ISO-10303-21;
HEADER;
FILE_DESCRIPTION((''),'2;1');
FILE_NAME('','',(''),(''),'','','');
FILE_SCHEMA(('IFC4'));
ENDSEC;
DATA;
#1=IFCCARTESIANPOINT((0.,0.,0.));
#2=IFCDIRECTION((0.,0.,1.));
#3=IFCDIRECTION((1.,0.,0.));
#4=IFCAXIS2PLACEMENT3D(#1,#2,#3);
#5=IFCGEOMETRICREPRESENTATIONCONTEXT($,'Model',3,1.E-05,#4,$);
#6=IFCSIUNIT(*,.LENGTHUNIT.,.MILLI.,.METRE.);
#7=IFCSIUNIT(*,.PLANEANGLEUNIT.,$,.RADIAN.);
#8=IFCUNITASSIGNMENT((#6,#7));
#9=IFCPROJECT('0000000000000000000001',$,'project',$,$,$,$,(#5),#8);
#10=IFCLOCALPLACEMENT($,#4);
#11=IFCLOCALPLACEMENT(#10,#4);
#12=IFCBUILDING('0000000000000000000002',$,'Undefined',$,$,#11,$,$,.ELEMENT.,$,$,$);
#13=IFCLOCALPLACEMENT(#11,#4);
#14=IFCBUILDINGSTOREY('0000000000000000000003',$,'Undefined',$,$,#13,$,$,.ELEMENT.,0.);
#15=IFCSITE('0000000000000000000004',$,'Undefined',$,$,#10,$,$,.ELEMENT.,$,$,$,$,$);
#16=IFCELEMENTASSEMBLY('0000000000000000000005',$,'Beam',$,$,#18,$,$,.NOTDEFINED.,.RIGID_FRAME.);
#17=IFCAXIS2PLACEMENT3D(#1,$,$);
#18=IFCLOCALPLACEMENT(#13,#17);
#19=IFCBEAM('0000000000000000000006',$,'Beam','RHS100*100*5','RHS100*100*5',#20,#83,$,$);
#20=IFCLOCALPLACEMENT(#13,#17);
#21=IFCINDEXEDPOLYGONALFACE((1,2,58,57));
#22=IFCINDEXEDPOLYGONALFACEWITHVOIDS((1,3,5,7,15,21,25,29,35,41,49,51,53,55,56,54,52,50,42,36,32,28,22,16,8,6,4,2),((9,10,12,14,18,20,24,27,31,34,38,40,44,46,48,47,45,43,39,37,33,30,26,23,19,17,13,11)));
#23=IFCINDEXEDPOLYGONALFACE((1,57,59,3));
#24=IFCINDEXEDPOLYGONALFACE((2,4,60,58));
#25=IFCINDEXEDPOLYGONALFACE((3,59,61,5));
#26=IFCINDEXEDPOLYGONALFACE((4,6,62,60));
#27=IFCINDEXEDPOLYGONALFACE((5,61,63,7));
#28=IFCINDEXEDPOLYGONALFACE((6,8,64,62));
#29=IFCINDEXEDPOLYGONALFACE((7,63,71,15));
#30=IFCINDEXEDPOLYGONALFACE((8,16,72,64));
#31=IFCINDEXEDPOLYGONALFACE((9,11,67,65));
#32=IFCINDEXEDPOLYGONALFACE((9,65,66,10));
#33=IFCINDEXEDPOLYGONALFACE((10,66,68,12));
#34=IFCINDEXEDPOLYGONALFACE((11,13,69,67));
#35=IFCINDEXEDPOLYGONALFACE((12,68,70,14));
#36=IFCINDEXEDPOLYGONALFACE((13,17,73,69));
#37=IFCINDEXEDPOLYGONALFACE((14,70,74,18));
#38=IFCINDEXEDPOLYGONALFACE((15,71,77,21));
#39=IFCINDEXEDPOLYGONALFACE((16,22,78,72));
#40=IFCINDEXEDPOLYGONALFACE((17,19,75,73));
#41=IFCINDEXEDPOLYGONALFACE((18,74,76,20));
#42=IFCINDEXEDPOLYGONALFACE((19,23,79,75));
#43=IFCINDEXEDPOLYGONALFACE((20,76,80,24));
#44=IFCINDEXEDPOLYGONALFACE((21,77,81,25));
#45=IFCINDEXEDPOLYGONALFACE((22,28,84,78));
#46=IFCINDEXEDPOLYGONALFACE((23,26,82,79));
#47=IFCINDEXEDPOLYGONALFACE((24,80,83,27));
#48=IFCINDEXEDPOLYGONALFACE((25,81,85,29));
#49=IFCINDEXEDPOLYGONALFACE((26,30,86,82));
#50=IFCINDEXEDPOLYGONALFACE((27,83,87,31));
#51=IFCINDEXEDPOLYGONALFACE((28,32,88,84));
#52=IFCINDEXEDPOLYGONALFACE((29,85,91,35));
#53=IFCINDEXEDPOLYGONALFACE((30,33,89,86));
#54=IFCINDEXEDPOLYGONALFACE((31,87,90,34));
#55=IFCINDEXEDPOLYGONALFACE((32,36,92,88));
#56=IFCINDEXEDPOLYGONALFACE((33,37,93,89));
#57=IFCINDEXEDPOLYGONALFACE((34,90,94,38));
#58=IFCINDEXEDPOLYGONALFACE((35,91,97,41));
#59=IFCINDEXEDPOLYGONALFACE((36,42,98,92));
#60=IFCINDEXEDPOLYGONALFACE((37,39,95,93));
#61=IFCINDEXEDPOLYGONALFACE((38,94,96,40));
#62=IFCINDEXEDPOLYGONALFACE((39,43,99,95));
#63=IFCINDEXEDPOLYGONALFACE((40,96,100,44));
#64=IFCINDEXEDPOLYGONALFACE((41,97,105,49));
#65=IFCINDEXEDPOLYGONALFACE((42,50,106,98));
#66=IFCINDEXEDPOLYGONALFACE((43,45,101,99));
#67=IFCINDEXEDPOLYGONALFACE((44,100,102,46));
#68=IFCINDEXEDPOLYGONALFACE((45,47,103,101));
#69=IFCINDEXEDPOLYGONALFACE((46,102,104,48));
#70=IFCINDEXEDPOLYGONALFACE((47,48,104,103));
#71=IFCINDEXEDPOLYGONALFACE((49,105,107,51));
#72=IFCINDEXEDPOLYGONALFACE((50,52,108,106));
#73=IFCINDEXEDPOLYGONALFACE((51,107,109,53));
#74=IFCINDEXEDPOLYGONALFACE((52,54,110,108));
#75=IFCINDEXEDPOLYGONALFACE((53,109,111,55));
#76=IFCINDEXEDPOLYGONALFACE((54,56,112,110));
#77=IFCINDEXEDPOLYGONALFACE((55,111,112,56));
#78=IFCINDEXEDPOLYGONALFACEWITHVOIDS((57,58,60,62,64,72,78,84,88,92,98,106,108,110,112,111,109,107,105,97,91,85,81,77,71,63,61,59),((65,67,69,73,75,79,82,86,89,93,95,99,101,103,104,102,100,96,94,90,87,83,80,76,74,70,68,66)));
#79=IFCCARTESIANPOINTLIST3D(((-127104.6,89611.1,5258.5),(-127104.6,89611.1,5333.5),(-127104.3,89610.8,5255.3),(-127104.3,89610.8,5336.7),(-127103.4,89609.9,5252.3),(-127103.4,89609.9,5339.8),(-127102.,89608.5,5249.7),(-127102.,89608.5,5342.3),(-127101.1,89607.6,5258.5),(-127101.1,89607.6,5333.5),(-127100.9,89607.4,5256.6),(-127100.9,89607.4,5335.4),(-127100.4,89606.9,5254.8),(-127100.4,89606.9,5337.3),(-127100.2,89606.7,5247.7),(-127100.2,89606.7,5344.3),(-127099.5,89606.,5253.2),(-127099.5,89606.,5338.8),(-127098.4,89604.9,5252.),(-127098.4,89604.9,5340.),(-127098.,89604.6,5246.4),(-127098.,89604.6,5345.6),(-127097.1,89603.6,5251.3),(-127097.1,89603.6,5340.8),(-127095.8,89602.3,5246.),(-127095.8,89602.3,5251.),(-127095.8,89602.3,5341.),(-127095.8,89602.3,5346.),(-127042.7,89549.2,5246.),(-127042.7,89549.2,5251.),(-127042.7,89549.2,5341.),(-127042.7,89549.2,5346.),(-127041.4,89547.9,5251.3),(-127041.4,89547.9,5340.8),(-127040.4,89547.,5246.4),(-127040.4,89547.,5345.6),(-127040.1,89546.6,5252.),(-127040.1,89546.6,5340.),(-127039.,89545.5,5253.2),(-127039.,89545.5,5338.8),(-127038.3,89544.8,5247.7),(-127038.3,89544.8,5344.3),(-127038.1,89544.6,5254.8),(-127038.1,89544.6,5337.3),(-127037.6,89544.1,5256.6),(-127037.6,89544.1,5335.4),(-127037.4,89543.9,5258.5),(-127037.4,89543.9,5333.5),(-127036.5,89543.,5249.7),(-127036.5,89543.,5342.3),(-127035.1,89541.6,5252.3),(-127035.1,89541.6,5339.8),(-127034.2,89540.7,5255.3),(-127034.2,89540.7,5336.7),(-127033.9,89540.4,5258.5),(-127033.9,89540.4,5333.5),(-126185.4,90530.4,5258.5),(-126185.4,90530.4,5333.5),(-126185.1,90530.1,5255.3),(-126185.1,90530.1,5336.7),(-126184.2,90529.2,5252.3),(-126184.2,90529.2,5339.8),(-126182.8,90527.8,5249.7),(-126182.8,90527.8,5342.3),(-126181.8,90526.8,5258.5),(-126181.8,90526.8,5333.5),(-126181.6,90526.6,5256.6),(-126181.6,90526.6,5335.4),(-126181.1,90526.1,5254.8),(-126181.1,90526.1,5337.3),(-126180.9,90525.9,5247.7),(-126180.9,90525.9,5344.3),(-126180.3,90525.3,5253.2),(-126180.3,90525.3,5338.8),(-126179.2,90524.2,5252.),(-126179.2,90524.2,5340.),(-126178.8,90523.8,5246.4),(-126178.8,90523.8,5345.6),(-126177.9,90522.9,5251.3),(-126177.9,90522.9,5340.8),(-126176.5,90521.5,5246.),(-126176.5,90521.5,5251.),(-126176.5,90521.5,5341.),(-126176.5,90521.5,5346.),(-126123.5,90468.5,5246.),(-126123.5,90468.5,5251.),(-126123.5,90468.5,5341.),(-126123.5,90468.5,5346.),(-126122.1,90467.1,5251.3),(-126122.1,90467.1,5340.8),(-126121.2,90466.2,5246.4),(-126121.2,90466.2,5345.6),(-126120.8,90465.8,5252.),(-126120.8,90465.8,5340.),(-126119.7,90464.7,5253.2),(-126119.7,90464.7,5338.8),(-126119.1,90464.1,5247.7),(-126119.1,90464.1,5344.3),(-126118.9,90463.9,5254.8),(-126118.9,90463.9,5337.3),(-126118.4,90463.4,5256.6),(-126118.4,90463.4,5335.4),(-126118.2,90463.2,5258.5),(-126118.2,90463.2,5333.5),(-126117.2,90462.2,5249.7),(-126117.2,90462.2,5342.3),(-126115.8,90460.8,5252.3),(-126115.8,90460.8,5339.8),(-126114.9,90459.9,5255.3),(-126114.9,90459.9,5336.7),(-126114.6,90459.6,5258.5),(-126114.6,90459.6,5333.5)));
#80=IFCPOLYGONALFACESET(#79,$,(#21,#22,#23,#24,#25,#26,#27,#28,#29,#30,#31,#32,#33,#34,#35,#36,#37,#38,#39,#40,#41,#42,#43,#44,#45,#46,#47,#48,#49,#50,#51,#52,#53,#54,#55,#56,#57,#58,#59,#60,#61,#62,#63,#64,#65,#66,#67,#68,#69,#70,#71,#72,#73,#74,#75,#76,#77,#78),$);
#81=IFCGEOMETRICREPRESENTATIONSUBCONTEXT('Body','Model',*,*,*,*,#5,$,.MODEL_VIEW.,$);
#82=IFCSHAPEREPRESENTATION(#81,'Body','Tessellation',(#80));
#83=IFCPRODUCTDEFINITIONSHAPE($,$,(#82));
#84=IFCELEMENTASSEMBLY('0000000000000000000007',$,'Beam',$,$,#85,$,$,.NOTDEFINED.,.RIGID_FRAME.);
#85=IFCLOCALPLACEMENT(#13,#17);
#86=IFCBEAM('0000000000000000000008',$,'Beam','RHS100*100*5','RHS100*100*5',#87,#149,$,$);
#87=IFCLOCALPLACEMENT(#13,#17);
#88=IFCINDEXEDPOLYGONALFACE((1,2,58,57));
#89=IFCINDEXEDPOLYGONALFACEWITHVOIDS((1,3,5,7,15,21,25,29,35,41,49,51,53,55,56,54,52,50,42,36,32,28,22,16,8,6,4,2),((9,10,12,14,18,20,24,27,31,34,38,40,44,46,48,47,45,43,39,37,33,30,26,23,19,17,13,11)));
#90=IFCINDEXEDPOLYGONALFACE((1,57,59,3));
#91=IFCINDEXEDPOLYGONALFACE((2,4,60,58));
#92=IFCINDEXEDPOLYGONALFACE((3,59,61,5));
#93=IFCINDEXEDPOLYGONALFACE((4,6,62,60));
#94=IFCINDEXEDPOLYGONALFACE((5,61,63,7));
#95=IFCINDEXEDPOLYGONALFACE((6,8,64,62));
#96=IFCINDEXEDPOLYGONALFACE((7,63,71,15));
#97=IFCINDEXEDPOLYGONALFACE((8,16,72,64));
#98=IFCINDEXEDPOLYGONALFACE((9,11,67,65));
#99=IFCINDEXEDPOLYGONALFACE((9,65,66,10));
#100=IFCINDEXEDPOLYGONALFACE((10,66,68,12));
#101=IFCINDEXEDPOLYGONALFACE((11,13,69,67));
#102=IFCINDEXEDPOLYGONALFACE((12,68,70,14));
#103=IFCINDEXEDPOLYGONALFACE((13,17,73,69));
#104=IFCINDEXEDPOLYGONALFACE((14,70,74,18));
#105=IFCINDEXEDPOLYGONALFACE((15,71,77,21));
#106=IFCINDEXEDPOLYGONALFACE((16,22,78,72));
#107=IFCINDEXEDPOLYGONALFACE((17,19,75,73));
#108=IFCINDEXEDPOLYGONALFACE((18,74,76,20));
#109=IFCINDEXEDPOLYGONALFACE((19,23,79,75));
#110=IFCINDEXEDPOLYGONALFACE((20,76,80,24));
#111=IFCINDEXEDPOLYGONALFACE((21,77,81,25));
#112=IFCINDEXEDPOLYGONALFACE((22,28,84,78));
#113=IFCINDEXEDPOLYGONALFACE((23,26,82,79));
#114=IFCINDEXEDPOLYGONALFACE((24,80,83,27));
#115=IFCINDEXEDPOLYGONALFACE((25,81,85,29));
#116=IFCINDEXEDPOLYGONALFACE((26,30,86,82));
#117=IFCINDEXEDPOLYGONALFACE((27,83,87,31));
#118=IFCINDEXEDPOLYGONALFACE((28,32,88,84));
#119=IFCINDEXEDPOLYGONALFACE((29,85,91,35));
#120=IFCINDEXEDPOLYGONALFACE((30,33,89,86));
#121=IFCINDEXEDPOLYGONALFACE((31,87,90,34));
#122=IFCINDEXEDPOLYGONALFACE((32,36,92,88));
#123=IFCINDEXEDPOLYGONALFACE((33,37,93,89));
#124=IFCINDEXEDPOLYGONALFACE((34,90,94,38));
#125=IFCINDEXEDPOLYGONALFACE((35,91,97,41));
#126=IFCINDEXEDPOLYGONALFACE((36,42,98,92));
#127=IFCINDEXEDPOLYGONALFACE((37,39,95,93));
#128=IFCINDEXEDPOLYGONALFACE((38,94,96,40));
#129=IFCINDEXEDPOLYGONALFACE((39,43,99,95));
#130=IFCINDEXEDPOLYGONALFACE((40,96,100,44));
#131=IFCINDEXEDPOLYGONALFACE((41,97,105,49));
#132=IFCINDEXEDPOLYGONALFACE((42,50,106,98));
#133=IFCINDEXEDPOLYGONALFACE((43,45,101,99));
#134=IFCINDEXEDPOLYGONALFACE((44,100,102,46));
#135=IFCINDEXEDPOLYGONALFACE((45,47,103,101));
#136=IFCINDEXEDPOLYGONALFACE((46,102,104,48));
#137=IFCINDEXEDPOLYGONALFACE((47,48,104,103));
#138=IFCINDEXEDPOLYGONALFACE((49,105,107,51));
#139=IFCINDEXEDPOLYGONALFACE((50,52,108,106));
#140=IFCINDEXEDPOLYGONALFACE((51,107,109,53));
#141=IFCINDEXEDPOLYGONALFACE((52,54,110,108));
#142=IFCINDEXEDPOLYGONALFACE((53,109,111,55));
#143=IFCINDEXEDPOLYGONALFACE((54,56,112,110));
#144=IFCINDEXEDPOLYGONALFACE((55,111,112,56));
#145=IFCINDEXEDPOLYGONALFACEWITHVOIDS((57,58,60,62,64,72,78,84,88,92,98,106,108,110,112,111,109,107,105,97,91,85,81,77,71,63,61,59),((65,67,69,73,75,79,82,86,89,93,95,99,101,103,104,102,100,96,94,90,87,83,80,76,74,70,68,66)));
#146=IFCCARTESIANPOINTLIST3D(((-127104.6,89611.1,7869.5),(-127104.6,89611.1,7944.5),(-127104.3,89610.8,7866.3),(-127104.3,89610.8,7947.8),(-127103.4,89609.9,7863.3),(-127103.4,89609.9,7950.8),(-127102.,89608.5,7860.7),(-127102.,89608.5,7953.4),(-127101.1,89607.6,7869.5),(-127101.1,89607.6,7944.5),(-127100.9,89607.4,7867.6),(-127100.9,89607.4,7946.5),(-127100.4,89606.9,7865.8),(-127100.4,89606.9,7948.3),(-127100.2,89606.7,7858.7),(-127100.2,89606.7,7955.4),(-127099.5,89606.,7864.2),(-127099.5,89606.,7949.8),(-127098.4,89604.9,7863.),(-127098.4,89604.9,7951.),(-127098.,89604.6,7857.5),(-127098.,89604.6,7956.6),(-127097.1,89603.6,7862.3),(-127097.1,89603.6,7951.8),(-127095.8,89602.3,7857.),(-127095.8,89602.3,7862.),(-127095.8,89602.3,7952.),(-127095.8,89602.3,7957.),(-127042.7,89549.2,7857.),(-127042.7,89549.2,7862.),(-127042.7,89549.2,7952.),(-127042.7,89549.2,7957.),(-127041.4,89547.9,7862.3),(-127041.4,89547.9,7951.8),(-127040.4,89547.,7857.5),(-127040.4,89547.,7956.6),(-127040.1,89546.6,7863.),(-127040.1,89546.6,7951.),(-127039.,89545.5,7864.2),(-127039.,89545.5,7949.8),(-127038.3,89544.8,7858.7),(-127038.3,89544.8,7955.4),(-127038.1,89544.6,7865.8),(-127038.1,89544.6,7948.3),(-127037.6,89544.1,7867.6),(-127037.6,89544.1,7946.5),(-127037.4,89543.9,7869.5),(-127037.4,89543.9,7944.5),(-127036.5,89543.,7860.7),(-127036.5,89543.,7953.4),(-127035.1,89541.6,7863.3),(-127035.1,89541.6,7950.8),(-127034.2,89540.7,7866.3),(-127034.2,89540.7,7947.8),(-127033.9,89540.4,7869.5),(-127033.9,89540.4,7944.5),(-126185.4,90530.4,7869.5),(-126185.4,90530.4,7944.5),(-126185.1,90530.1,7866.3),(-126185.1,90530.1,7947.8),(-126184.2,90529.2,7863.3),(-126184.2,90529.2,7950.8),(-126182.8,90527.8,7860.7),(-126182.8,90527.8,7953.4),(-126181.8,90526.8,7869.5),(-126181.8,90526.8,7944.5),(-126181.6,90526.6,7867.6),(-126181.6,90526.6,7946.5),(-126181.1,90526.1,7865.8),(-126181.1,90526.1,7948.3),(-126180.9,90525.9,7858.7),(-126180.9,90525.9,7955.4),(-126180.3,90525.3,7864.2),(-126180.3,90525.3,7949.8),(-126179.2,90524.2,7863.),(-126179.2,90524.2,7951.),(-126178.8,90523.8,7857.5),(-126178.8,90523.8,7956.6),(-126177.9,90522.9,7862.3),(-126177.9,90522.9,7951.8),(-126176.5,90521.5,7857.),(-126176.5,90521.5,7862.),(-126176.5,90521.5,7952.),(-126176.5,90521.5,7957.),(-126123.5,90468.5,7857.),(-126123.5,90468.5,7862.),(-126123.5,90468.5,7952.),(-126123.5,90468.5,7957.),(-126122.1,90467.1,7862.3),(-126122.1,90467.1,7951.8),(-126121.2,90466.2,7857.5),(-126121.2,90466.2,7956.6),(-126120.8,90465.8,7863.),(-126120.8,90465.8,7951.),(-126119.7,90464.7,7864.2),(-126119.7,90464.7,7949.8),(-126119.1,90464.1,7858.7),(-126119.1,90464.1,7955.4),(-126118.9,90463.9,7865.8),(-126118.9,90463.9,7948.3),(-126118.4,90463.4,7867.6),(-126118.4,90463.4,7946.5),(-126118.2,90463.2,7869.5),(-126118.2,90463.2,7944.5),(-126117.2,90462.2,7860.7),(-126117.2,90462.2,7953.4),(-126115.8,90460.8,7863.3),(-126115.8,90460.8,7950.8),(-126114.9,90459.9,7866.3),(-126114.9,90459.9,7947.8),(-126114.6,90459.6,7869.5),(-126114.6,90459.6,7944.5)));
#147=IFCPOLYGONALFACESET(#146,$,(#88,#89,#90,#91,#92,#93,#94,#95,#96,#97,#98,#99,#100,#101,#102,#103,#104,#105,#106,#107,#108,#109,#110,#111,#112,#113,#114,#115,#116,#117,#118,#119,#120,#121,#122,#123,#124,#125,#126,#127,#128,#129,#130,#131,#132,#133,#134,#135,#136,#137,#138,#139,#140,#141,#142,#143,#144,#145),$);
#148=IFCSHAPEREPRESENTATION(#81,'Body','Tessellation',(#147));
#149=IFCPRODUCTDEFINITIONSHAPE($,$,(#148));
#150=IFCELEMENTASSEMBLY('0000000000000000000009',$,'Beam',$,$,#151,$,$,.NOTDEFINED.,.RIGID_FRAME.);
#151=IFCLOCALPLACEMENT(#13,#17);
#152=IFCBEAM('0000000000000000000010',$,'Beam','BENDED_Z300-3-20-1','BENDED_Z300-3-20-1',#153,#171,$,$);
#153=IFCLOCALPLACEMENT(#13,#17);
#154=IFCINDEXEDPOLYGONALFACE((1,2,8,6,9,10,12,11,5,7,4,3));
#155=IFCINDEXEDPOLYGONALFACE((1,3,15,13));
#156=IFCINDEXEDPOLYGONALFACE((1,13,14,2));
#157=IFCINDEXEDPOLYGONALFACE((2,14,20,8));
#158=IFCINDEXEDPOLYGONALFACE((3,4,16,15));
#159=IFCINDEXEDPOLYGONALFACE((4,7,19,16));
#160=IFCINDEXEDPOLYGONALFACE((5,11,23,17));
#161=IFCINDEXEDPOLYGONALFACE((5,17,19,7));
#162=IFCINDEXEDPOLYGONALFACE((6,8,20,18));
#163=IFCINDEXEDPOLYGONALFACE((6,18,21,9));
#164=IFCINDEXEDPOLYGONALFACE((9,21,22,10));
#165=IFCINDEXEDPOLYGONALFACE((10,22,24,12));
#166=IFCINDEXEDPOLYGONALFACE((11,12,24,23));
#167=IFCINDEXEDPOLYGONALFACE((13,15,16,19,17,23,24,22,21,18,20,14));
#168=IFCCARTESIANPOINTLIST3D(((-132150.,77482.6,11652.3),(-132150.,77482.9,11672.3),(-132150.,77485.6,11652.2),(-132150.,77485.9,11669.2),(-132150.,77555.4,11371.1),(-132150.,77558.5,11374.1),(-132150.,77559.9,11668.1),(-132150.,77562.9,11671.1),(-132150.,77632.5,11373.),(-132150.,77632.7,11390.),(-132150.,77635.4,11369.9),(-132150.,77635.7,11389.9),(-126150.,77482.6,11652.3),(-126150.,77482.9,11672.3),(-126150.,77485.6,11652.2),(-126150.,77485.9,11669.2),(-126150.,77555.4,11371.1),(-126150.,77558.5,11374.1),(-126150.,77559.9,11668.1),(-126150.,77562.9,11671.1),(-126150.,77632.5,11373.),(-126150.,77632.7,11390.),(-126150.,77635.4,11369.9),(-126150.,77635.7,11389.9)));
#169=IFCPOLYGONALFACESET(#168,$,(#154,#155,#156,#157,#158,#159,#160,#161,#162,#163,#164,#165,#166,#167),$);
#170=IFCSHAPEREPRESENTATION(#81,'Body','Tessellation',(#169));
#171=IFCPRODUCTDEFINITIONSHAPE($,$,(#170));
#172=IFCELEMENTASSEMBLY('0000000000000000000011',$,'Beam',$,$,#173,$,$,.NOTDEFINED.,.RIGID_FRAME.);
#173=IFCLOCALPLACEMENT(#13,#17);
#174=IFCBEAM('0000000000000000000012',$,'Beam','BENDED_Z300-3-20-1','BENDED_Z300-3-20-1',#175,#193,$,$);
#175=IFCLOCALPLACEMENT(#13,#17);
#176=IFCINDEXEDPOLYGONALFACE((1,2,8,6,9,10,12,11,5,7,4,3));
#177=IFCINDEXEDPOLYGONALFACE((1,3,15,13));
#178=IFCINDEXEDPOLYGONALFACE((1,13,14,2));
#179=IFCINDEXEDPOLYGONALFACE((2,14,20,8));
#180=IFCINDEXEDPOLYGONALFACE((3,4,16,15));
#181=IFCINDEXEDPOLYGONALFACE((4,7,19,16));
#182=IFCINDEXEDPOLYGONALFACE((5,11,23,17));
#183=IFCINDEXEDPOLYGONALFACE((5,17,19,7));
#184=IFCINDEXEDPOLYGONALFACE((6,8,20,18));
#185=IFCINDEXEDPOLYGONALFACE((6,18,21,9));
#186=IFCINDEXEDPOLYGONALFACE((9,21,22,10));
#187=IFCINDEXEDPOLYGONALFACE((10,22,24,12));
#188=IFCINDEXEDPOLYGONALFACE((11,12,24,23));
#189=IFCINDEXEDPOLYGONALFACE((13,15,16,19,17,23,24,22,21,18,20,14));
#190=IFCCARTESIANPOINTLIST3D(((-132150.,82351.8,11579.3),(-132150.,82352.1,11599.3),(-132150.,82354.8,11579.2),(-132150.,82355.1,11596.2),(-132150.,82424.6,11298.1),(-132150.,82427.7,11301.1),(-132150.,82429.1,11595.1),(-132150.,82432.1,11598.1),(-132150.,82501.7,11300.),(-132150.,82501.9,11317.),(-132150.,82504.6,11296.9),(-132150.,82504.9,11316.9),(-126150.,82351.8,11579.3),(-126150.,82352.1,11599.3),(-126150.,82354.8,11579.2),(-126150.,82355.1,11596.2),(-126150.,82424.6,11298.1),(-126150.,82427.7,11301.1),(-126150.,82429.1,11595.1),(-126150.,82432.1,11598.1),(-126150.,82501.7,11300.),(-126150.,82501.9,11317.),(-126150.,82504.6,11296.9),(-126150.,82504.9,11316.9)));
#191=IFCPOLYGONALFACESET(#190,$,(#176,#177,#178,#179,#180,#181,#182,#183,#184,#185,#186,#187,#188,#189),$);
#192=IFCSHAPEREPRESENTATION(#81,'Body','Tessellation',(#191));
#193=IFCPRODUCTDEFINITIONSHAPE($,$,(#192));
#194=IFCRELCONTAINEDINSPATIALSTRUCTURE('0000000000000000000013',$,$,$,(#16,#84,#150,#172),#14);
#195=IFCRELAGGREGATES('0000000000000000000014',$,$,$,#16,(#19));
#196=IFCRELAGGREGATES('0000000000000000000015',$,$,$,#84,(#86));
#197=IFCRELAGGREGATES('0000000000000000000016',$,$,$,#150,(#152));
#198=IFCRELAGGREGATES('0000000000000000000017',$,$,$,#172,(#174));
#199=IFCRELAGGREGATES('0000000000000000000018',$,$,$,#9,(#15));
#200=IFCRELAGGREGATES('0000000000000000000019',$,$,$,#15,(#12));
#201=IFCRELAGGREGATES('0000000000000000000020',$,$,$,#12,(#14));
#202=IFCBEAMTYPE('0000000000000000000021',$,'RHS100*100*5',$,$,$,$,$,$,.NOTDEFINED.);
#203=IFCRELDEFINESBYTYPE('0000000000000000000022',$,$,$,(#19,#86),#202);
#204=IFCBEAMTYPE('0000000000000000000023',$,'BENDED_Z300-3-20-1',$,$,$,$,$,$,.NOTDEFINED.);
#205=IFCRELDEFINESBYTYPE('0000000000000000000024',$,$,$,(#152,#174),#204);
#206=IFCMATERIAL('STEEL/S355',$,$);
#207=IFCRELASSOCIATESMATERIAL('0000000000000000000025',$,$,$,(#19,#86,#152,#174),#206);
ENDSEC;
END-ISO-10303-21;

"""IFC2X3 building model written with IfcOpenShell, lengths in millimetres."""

from ifc_helpers import new_model, si_unit, frame, origin_with_axes, origin_2d_with_axis, place, context, subcontext, project, spatial, polyline, hollow_rectangle, outline, extrude, material, type_object, element, aggregate, save


model = new_model("IFC2X3")

# Units and contexts
model_context = context("Model", 3, precision=1e-05, world=origin_with_axes())
body_context = subcontext(model_context, "Body", "Model", "MODEL_VIEW")
ifc_project = project(units=[si_unit("LENGTHUNIT", "METRE", prefix="MILLI"), si_unit("PLANEANGLEUNIT", "RADIAN")], contexts=[model_context])

# Site, building, storey
site_placement = place(None, origin_with_axes())
site = spatial("IfcSite", under=ifc_project, at=site_placement, Name="Undefined", CompositionType="ELEMENT")
building_placement = place(site_placement, origin_with_axes())
building = spatial("IfcBuilding", under=site, at=building_placement, Name="Undefined", CompositionType="ELEMENT")
storey_placement = place(building_placement, origin_with_axes())
storey = spatial("IfcBuildingStorey", under=building, at=storey_placement, Name="Undefined", CompositionType="ELEMENT", Elevation=0.0)

# Element assemblies, beams
ifc_material_1 = material(Name="STEEL/S355")
beam_type_1 = type_object("IfcBeamType", Name="RHS100*100*5", PredefinedType="NOTDEFINED")
assembly_1_placement = place(storey_placement, origin_with_axes())
assembly_1 = element("IfcElementAssembly", 1, at=assembly_1_placement, inside=storey, Name="Beam", AssemblyPlace="NOTDEFINED", PredefinedType="RIGID_FRAME")
beam_1_placement = place(assembly_1_placement, frame((-127069.2, 89575.8, 5296.0), z_axis=(0.0, 0.0, 1.0), x_axis=(0.707107, 0.707107, 0.0)))
beam_1 = element("IfcBeam", 2, at=beam_1_placement, type_object=beam_type_1, material=ifc_material_1, Name="Beam", Description="RHS100*100*5", ObjectType="RHS100*100*5", context=body_context, shape_type="SweptSolid", body=[
    extrude(hollow_rectangle(XDim=100.0, YDim=100.0, WallThickness=5.0, InnerFilletRadius=7.5, OuterFilletRadius=12.5, at=origin_2d_with_axis()), frame((1300.0, 0.0, 0.0), z_axis=(-1.0, 0.0, 0.0), x_axis=(0.0, -1.0, 0.0)), (0.0, 0.0, 1.0), 1300.0),
])
aggregate(assembly_1, [beam_1])
assembly_2_placement = place(storey_placement, origin_with_axes())
assembly_2 = element("IfcElementAssembly", 3, at=assembly_2_placement, inside=storey, Name="Beam", AssemblyPlace="NOTDEFINED", PredefinedType="RIGID_FRAME")
beam_2_placement = place(assembly_2_placement, frame((-127069.2, 89575.8, 7907.0), z_axis=(0.0, 0.0, 1.0), x_axis=(0.707107, 0.707107, 0.0)))
beam_2 = element("IfcBeam", 4, at=beam_2_placement, type_object=beam_type_1, material=ifc_material_1, Name="Beam", Description="RHS100*100*5", ObjectType="RHS100*100*5", context=body_context, shape_type="SweptSolid", body=[
    extrude(hollow_rectangle(XDim=100.0, YDim=100.0, WallThickness=5.0, InnerFilletRadius=7.5, OuterFilletRadius=12.5, at=origin_2d_with_axis()), frame((1300.0, 0.0, 0.0), z_axis=(-1.0, 0.0, 0.0), x_axis=(0.0, -1.0, 0.0)), (0.0, 0.0, 1.0), 1300.0),
])
aggregate(assembly_2, [beam_2])
assembly_3_placement = place(storey_placement, origin_with_axes())
assembly_3 = element("IfcElementAssembly", 5, at=assembly_3_placement, inside=storey, Name="Beam", AssemblyPlace="NOTDEFINED", PredefinedType="RIGID_FRAME")
beam_type_2 = type_object("IfcBeamType", Name="BENDED_Z300-3-20-1", PredefinedType="NOTDEFINED")
beam_3_placement = place(assembly_3_placement, frame((-132150.0, 77559.2, 11521.1), z_axis=(0.0, 0.014963, 0.999888), x_axis=(1.0, 0.0, 0.0)))
beam_3 = element("IfcBeam", 6, at=beam_3_placement, type_object=beam_type_2, material=ifc_material_1, Name="Beam", Description="BENDED_Z300-3-20-1", ObjectType="BENDED_Z300-3-20-1", context=body_context, shape_type="SweptSolid", body=[
    extrude(outline(polyline([(1.5, -150.0), (-78.5, -150.0), (-78.5, -130.0), (-75.5, -130.0), (-75.5, -147.0), (-1.5, -147.0), (-1.5, 150.0), (78.5, 150.0), (78.5, 130.0), (75.5, 130.0), (75.5, 147.0), (1.5, 147.0), (1.5, -150.0)])), frame((6000.0, 0.0, 0.0), z_axis=(-1.0, 0.0, 0.0), x_axis=(0.0, -1.0, 0.0)), (0.0, 0.0, 1.0), 6000.0),
])
aggregate(assembly_3, [beam_3])
assembly_4_placement = place(storey_placement, origin_with_axes())
assembly_4 = element("IfcElementAssembly", 7, at=assembly_4_placement, inside=storey, Name="Beam", AssemblyPlace="NOTDEFINED", PredefinedType="RIGID_FRAME")
beam_4_placement = place(assembly_4_placement, frame((-132150.0, 82428.4, 11448.1), z_axis=(0.0, 0.014963, 0.999888), x_axis=(1.0, 0.0, 0.0)))
beam_4 = element("IfcBeam", 8, at=beam_4_placement, type_object=beam_type_2, material=ifc_material_1, Name="Beam", Description="BENDED_Z300-3-20-1", ObjectType="BENDED_Z300-3-20-1", context=body_context, shape_type="SweptSolid", body=[
    extrude(outline(polyline([(1.5, -150.0), (-78.5, -150.0), (-78.5, -130.0), (-75.5, -130.0), (-75.5, -147.0), (-1.5, -147.0), (-1.5, 150.0), (78.5, 150.0), (78.5, 130.0), (75.5, 130.0), (75.5, 147.0), (1.5, 147.0), (1.5, -150.0)])), frame((6000.0, 0.0, 0.0), z_axis=(-1.0, 0.0, 0.0), x_axis=(0.0, -1.0, 0.0)), (0.0, 0.0, 1.0), 6000.0),
])
aggregate(assembly_4, [beam_4])

save(model, "model.ifc")
